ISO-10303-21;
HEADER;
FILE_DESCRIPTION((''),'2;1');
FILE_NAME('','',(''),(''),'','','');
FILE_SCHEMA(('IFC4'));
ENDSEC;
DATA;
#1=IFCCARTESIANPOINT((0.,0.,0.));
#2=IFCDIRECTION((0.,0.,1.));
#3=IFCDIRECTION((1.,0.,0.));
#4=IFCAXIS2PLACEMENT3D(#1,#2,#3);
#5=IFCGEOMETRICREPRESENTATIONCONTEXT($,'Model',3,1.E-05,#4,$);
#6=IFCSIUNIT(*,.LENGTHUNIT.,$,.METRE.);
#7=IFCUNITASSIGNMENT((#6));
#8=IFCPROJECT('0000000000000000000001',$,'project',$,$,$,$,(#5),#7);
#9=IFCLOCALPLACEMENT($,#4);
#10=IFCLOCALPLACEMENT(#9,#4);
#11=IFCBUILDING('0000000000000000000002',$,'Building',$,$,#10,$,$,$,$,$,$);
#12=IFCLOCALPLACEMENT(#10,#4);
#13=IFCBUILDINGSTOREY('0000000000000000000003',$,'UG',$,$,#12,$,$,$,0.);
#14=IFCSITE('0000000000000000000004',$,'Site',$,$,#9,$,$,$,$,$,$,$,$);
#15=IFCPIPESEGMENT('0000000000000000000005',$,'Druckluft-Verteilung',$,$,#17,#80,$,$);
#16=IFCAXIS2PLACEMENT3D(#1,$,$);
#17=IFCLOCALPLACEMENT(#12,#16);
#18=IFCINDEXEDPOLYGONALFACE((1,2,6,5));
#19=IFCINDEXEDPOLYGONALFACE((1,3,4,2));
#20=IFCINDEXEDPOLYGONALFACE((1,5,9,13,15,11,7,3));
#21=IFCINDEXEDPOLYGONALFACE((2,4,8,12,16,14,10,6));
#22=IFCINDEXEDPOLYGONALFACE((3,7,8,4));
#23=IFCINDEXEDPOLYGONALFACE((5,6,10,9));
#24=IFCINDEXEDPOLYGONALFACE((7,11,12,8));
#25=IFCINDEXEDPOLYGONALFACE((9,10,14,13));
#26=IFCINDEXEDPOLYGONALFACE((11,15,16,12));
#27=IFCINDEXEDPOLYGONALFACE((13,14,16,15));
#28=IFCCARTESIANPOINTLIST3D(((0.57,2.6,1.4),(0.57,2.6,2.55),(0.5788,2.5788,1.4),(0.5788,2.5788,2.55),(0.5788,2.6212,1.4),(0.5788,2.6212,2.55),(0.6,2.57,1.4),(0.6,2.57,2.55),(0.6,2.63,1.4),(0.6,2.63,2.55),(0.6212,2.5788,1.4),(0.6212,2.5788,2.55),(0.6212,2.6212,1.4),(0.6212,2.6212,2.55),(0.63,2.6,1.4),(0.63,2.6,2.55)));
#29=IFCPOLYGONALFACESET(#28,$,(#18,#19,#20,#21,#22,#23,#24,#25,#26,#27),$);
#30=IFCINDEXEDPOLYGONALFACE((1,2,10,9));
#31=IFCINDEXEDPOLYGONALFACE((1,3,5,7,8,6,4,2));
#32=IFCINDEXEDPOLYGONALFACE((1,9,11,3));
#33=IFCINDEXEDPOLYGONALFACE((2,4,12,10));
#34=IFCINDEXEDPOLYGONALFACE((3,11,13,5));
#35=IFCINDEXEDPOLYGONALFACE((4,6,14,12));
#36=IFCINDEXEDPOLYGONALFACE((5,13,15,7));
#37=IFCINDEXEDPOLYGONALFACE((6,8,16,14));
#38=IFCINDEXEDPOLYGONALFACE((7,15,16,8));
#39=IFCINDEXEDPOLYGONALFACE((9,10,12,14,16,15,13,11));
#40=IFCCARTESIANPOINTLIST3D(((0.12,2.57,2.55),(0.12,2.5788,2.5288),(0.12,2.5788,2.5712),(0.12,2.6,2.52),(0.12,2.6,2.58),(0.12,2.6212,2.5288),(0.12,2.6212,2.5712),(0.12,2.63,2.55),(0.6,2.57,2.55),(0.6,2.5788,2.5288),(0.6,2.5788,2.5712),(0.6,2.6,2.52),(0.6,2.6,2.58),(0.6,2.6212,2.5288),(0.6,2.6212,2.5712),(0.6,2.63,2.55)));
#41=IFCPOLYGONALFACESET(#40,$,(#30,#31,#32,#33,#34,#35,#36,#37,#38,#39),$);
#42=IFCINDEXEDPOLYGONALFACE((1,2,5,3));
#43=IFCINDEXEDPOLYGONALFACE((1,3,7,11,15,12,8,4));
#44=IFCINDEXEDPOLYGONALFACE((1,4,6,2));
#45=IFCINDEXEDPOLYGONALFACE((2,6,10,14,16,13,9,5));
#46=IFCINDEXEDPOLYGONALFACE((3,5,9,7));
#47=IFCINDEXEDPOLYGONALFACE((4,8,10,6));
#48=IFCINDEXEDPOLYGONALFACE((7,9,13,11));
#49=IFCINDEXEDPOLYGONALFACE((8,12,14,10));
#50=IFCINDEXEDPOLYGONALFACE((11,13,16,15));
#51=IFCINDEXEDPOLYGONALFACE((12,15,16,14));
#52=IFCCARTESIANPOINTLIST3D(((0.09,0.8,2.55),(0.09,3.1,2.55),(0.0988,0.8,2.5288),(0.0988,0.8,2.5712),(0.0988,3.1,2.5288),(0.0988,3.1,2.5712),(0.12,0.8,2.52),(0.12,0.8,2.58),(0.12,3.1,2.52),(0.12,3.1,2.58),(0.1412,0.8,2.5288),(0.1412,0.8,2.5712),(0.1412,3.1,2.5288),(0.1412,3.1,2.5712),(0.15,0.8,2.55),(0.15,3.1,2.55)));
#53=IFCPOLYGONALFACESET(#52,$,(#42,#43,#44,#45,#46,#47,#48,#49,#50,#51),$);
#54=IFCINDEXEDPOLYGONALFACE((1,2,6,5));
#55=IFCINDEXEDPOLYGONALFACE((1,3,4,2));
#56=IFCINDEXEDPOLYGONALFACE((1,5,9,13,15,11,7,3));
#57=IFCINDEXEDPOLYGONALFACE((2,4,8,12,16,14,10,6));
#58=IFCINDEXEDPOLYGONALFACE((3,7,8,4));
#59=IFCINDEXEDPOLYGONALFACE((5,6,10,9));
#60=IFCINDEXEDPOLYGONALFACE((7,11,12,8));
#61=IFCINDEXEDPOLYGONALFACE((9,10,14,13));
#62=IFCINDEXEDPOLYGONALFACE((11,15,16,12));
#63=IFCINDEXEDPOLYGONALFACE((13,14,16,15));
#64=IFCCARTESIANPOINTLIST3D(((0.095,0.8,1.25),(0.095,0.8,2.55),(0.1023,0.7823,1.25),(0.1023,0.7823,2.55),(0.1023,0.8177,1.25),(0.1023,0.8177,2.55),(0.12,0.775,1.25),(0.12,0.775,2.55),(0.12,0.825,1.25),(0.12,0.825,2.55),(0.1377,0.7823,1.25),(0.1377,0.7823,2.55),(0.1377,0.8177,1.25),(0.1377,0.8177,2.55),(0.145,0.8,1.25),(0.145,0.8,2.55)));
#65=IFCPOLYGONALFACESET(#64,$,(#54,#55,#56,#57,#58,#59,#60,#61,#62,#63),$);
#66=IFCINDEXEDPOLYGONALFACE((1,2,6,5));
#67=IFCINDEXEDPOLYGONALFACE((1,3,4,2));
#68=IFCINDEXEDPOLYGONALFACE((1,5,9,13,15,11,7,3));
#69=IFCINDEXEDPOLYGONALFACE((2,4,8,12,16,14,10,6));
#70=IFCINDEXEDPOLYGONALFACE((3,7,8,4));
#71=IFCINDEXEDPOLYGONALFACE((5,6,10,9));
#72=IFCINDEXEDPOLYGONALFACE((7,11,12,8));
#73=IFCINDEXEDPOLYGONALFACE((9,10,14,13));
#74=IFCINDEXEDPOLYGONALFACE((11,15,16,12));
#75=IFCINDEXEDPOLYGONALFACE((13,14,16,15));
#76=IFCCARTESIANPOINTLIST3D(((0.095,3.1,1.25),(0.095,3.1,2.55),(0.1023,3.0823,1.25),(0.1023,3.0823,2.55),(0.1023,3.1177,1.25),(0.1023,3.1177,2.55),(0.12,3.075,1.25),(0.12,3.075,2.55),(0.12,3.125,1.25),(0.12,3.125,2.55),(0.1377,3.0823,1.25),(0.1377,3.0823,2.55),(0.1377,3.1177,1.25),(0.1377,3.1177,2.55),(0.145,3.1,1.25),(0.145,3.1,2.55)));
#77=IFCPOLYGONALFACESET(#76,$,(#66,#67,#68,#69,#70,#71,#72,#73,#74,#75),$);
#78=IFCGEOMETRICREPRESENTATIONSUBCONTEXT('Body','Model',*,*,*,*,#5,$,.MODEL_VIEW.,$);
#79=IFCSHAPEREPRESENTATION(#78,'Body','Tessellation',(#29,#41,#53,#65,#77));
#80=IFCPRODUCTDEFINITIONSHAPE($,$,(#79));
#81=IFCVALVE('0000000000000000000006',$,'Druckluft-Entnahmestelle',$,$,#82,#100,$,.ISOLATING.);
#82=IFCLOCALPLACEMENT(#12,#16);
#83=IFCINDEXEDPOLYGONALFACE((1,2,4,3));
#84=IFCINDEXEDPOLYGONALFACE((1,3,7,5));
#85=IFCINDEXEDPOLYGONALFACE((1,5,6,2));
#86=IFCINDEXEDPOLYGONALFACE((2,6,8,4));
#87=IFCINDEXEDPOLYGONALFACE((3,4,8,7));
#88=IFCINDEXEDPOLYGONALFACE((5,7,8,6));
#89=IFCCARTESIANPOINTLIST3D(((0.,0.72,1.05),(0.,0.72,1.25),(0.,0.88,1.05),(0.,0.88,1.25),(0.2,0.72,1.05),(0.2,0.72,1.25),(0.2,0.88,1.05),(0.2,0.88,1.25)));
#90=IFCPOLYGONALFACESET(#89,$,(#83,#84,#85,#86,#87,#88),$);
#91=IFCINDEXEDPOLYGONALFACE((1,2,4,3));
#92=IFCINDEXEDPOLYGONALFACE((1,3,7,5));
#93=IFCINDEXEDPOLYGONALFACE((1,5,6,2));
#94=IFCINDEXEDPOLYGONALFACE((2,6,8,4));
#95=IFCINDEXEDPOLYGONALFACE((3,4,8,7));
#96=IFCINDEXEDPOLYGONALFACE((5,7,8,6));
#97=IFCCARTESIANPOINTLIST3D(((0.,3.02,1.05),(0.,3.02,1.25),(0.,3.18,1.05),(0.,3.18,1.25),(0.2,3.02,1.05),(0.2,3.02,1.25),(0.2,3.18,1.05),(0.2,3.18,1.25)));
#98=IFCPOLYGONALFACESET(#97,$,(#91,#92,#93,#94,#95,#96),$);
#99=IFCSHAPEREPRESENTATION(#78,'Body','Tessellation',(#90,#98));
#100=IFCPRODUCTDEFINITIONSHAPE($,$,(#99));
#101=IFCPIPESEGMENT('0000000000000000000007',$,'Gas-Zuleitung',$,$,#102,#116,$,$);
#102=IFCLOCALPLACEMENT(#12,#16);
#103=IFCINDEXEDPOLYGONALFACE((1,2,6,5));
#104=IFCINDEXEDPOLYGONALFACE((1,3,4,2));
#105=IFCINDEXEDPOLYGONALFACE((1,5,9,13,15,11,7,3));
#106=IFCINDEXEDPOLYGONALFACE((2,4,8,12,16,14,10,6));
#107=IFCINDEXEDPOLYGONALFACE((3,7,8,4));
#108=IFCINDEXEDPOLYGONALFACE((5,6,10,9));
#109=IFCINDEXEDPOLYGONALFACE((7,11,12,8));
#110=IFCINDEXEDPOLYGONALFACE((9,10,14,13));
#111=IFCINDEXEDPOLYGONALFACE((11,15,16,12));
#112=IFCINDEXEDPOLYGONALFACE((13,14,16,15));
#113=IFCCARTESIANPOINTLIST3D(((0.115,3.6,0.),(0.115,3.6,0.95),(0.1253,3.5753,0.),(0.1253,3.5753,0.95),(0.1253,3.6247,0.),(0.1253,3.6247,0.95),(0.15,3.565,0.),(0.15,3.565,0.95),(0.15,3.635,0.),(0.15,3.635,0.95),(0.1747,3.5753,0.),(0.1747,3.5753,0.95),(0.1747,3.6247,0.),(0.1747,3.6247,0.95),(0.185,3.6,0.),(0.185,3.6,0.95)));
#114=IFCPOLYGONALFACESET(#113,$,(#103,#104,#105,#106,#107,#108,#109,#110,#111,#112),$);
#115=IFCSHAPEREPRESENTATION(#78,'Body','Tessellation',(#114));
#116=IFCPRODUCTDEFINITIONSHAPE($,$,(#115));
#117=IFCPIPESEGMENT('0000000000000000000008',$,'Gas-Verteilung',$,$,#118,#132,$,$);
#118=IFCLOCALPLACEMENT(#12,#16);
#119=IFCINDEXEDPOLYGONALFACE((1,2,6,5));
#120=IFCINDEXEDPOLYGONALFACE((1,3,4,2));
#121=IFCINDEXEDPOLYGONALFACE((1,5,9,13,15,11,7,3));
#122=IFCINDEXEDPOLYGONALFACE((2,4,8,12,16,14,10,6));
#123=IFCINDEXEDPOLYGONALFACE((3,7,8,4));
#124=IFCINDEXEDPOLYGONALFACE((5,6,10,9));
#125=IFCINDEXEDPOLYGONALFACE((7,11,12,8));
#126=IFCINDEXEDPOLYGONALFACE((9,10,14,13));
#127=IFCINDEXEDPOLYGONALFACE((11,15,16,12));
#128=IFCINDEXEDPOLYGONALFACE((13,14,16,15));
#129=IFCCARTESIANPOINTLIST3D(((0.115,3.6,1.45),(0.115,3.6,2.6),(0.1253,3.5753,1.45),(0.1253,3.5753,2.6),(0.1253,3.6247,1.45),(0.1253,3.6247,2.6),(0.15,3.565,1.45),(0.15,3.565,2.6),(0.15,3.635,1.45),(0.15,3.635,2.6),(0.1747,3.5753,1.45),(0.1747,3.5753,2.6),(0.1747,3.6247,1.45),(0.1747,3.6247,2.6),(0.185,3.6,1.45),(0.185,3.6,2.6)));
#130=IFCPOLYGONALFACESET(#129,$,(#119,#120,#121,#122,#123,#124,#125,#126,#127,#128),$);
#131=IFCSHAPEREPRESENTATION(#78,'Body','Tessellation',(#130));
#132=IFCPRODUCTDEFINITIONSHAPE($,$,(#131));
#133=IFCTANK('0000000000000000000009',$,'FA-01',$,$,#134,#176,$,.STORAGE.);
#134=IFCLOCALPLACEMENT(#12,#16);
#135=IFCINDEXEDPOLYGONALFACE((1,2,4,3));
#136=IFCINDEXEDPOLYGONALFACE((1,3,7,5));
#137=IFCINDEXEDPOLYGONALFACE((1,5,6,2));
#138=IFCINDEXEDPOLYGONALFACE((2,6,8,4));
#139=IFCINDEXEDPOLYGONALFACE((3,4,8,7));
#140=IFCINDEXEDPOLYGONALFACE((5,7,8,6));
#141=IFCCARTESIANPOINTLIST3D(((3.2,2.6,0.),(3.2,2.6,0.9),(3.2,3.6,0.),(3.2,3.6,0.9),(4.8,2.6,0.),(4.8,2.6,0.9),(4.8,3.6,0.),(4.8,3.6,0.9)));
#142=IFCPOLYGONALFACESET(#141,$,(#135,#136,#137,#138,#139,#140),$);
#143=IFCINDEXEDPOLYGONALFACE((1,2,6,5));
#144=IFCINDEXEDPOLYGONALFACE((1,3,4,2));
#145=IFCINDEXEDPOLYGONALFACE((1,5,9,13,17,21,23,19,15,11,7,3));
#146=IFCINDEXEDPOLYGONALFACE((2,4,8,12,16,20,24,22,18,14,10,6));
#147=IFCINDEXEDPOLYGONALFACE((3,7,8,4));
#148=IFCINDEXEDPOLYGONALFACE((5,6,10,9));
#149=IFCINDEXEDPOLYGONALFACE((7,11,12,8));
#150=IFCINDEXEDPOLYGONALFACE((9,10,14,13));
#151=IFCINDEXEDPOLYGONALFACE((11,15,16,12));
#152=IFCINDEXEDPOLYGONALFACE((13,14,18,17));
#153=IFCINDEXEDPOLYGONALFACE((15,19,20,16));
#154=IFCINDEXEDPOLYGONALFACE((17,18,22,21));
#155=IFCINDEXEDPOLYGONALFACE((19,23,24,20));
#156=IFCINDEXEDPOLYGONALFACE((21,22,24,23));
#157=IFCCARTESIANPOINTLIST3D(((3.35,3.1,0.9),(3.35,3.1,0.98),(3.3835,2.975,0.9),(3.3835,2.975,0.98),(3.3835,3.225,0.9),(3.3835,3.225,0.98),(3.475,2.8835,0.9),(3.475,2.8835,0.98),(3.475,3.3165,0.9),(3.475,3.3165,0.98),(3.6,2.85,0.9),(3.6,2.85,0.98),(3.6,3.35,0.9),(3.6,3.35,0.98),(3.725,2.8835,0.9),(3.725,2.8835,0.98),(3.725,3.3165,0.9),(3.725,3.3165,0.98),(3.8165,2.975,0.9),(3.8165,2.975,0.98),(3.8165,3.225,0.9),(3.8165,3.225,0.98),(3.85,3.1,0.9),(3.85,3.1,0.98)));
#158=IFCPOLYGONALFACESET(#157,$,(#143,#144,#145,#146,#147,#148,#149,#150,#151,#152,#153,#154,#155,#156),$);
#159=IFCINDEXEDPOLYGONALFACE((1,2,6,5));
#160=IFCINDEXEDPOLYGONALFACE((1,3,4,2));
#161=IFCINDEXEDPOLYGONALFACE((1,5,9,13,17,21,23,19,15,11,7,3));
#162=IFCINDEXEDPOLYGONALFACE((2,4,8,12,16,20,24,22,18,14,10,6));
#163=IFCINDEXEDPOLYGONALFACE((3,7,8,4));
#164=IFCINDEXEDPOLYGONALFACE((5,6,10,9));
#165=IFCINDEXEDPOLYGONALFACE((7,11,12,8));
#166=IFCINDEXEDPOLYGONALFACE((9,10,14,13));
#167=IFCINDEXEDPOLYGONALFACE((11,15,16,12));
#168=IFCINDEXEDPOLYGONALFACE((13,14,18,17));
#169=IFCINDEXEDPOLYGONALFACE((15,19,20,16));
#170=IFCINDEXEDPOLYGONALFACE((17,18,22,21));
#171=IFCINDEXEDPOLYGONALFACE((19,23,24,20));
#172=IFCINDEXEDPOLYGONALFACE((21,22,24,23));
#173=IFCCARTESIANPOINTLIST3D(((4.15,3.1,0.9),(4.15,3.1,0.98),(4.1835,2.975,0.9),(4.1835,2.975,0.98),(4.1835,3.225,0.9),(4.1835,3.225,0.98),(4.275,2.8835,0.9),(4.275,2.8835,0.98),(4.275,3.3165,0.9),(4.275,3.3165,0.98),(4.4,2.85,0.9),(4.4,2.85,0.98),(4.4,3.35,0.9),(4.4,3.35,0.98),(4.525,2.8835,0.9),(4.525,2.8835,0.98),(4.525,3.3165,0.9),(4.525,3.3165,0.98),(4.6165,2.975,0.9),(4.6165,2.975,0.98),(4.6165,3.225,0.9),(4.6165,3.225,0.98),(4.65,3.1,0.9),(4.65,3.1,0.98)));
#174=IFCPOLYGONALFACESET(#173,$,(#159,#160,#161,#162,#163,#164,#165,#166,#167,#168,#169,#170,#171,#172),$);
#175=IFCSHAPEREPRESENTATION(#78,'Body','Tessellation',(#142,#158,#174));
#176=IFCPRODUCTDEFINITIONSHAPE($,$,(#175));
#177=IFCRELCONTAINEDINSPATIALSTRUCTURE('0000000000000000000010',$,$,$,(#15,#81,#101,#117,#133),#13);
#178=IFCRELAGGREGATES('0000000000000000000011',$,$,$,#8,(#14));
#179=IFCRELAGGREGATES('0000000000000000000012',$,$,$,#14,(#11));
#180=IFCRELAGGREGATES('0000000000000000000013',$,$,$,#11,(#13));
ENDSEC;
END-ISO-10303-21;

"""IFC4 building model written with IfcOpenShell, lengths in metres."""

from ifc_helpers import new_model, si_unit, frame, origin_with_axes, place, context, subcontext, project, spatial, polyline, outline, extrude, element, save


model = new_model("IFC4")

# Units and contexts
model_context = context("Model", 3, precision=1e-05, world=origin_with_axes())
body_context = subcontext(model_context, "Body", "Model", "MODEL_VIEW")
ifc_project = project(units=[si_unit("LENGTHUNIT", "METRE")], contexts=[model_context])

# Site, building, storey
site_placement = place(None, origin_with_axes())
site = spatial("IfcSite", under=ifc_project, at=site_placement, Name="Site")
building_placement = place(site_placement, origin_with_axes())
building = spatial("IfcBuilding", under=site, at=building_placement, Name="Building")
storey_placement = place(building_placement, origin_with_axes())
storey = spatial("IfcBuildingStorey", under=building, at=storey_placement, Name="UG", Elevation=0.0)

# Pipe segment
pipe_segment_1_placement = place(storey_placement, origin_with_axes())
element("IfcPipeSegment", 1, at=pipe_segment_1_placement, inside=storey, Name="Druckluft-Verteilung", context=body_context, shape_type="SweptSolid", body=[
    extrude(outline(polyline([(0.03, 0.0, 0.0), (0.0212, 0.0212, 0.0), (0.0, 0.03, 0.0), (-0.0212, 0.0212, 0.0), (-0.03, 0.0, 0.0), (-0.0212, -0.0212, 0.0), (0.0, -0.03, 0.0), (0.0212, -0.0212, 0.0), (0.03, 0.0, 0.0)])), frame((0.6, 2.6, 1.4), z_axis=(0.0, 0.0, 1.0), x_axis=(1.0, 0.0, 0.0)), (0.0, 0.0, 1.0), 1.15),
    extrude(outline(polyline([(0.03, 0.0, 0.0), (0.0212, 0.0212, 0.0), (0.0, 0.03, 0.0), (-0.0212, 0.0212, 0.0), (-0.03, 0.0, 0.0), (-0.0212, -0.0212, 0.0), (0.0, -0.03, 0.0), (0.0212, -0.0212, 0.0), (0.03, 0.0, 0.0)])), frame((0.6, 2.6, 2.55), z_axis=(-1.0, 0.0, 0.0), x_axis=(0.0, -1.0, 0.0)), (0.0, 0.0, 1.0), 0.48),
    extrude(outline(polyline([(0.03, 0.0, 0.0), (0.0212, 0.0212, 0.0), (0.0, 0.03, 0.0), (-0.0212, 0.0212, 0.0), (-0.03, 0.0, 0.0), (-0.0212, -0.0212, 0.0), (0.0, -0.03, 0.0), (0.0212, -0.0212, 0.0), (0.03, 0.0, 0.0)])), frame((0.12, 0.8, 2.55), z_axis=(0.0, 1.0, 0.0), x_axis=(-1.0, 0.0, 0.0)), (0.0, 0.0, 1.0), 2.3),
    extrude(outline(polyline([(0.025, 0.0, 0.0), (0.0177, 0.0177, 0.0), (0.0, 0.025, 0.0), (-0.0177, 0.0177, 0.0), (-0.025, 0.0, 0.0), (-0.0177, -0.0177, 0.0), (0.0, -0.025, 0.0), (0.0177, -0.0177, 0.0), (0.025, 0.0, 0.0)])), frame((0.12, 0.8, 2.55), z_axis=(0.0, 0.0, -1.0), x_axis=(1.0, 0.0, 0.0)), (0.0, 0.0, 1.0), 1.3),
    extrude(outline(polyline([(0.025, 0.0, 0.0), (0.0177, 0.0177, 0.0), (0.0, 0.025, 0.0), (-0.0177, 0.0177, 0.0), (-0.025, 0.0, 0.0), (-0.0177, -0.0177, 0.0), (0.0, -0.025, 0.0), (0.0177, -0.0177, 0.0), (0.025, 0.0, 0.0)])), frame((0.12, 3.1, 2.55), z_axis=(0.0, 0.0, -1.0), x_axis=(1.0, 0.0, 0.0)), (0.0, 0.0, 1.0), 1.3),
])

# Valve
valve_placement = place(storey_placement, origin_with_axes())
element("IfcValve", 2, at=valve_placement, inside=storey, Name="Druckluft-Entnahmestelle", PredefinedType="ISOLATING", context=body_context, shape_type="SweptSolid", body=[
    extrude(outline(polyline([(0.0, 0.72, 0.0), (0.2, 0.72, 0.0), (0.2, 0.88, 0.0), (0.0, 0.88, 0.0), (0.0, 0.72, 0.0)])), frame((0.0, 0.0, 1.05), z_axis=(0.0, 0.0, 1.0), x_axis=(1.0, 0.0, 0.0)), (0.0, 0.0, 1.0), 0.2),
    extrude(outline(polyline([(0.0, 3.02, 0.0), (0.2, 3.02, 0.0), (0.2, 3.18, 0.0), (0.0, 3.18, 0.0), (0.0, 3.02, 0.0)])), frame((0.0, 0.0, 1.05), z_axis=(0.0, 0.0, 1.0), x_axis=(1.0, 0.0, 0.0)), (0.0, 0.0, 1.0), 0.2),
])

# Pipe segments
pipe_segment_2_placement = place(storey_placement, origin_with_axes())
element("IfcPipeSegment", 3, at=pipe_segment_2_placement, inside=storey, Name="Gas-Zuleitung", context=body_context, shape_type="SweptSolid", body=[
    extrude(outline(polyline([(0.035, 0.0, 0.0), (0.0247, 0.0247, 0.0), (0.0, 0.035, 0.0), (-0.0247, 0.0247, 0.0), (-0.035, 0.0, 0.0), (-0.0247, -0.0247, 0.0), (0.0, -0.035, 0.0), (0.0247, -0.0247, 0.0), (0.035, 0.0, 0.0)])), frame((0.15, 3.6, 0.0), z_axis=(0.0, 0.0, 1.0), x_axis=(1.0, 0.0, 0.0)), (0.0, 0.0, 1.0), 0.95),
])
pipe_segment_3_placement = place(storey_placement, origin_with_axes())
element("IfcPipeSegment", 4, at=pipe_segment_3_placement, inside=storey, Name="Gas-Verteilung", context=body_context, shape_type="SweptSolid", body=[
    extrude(outline(polyline([(0.035, 0.0, 0.0), (0.0247, 0.0247, 0.0), (0.0, 0.035, 0.0), (-0.0247, 0.0247, 0.0), (-0.035, 0.0, 0.0), (-0.0247, -0.0247, 0.0), (0.0, -0.035, 0.0), (0.0247, -0.0247, 0.0), (0.035, 0.0, 0.0)])), frame((0.15, 3.6, 1.45), z_axis=(0.0, 0.0, 1.0), x_axis=(1.0, 0.0, 0.0)), (0.0, 0.0, 1.0), 1.15),
])

# Tank
tank_1_placement = place(storey_placement, origin_with_axes())
element("IfcTank", 5, at=tank_1_placement, inside=storey, Name="FA-01", PredefinedType="STORAGE", context=body_context, shape_type="SweptSolid", body=[
    extrude(outline(polyline([(3.2, 2.6, 0.0), (4.8, 2.6, 0.0), (4.8, 3.6, 0.0), (3.2, 3.6, 0.0), (3.2, 2.6, 0.0)])), origin_with_axes(), (0.0, 0.0, 1.0), 0.9),
    extrude(outline(polyline([(0.25, 0.0, 0.0), (0.2165, 0.125, 0.0), (0.125, 0.2165, 0.0), (0.0, 0.25, 0.0), (-0.125, 0.2165, 0.0), (-0.2165, 0.125, 0.0), (-0.25, 0.0, 0.0), (-0.2165, -0.125, 0.0), (-0.125, -0.2165, 0.0), (0.0, -0.25, 0.0), (0.125, -0.2165, 0.0), (0.2165, -0.125, 0.0), (0.25, 0.0, 0.0)])), frame((3.6, 3.1, 0.9), z_axis=(0.0, 0.0, 1.0), x_axis=(1.0, 0.0, 0.0)), (0.0, 0.0, 1.0), 0.08),
    extrude(outline(polyline([(0.25, 0.0, 0.0), (0.2165, 0.125, 0.0), (0.125, 0.2165, 0.0), (0.0, 0.25, 0.0), (-0.125, 0.2165, 0.0), (-0.2165, 0.125, 0.0), (-0.25, 0.0, 0.0), (-0.2165, -0.125, 0.0), (-0.125, -0.2165, 0.0), (0.0, -0.25, 0.0), (0.125, -0.2165, 0.0), (0.2165, -0.125, 0.0), (0.25, 0.0, 0.0)])), frame((4.4, 3.1, 0.9), z_axis=(0.0, 0.0, 1.0), x_axis=(1.0, 0.0, 0.0)), (0.0, 0.0, 1.0), 0.08),
])

save(model, "model.ifc")
